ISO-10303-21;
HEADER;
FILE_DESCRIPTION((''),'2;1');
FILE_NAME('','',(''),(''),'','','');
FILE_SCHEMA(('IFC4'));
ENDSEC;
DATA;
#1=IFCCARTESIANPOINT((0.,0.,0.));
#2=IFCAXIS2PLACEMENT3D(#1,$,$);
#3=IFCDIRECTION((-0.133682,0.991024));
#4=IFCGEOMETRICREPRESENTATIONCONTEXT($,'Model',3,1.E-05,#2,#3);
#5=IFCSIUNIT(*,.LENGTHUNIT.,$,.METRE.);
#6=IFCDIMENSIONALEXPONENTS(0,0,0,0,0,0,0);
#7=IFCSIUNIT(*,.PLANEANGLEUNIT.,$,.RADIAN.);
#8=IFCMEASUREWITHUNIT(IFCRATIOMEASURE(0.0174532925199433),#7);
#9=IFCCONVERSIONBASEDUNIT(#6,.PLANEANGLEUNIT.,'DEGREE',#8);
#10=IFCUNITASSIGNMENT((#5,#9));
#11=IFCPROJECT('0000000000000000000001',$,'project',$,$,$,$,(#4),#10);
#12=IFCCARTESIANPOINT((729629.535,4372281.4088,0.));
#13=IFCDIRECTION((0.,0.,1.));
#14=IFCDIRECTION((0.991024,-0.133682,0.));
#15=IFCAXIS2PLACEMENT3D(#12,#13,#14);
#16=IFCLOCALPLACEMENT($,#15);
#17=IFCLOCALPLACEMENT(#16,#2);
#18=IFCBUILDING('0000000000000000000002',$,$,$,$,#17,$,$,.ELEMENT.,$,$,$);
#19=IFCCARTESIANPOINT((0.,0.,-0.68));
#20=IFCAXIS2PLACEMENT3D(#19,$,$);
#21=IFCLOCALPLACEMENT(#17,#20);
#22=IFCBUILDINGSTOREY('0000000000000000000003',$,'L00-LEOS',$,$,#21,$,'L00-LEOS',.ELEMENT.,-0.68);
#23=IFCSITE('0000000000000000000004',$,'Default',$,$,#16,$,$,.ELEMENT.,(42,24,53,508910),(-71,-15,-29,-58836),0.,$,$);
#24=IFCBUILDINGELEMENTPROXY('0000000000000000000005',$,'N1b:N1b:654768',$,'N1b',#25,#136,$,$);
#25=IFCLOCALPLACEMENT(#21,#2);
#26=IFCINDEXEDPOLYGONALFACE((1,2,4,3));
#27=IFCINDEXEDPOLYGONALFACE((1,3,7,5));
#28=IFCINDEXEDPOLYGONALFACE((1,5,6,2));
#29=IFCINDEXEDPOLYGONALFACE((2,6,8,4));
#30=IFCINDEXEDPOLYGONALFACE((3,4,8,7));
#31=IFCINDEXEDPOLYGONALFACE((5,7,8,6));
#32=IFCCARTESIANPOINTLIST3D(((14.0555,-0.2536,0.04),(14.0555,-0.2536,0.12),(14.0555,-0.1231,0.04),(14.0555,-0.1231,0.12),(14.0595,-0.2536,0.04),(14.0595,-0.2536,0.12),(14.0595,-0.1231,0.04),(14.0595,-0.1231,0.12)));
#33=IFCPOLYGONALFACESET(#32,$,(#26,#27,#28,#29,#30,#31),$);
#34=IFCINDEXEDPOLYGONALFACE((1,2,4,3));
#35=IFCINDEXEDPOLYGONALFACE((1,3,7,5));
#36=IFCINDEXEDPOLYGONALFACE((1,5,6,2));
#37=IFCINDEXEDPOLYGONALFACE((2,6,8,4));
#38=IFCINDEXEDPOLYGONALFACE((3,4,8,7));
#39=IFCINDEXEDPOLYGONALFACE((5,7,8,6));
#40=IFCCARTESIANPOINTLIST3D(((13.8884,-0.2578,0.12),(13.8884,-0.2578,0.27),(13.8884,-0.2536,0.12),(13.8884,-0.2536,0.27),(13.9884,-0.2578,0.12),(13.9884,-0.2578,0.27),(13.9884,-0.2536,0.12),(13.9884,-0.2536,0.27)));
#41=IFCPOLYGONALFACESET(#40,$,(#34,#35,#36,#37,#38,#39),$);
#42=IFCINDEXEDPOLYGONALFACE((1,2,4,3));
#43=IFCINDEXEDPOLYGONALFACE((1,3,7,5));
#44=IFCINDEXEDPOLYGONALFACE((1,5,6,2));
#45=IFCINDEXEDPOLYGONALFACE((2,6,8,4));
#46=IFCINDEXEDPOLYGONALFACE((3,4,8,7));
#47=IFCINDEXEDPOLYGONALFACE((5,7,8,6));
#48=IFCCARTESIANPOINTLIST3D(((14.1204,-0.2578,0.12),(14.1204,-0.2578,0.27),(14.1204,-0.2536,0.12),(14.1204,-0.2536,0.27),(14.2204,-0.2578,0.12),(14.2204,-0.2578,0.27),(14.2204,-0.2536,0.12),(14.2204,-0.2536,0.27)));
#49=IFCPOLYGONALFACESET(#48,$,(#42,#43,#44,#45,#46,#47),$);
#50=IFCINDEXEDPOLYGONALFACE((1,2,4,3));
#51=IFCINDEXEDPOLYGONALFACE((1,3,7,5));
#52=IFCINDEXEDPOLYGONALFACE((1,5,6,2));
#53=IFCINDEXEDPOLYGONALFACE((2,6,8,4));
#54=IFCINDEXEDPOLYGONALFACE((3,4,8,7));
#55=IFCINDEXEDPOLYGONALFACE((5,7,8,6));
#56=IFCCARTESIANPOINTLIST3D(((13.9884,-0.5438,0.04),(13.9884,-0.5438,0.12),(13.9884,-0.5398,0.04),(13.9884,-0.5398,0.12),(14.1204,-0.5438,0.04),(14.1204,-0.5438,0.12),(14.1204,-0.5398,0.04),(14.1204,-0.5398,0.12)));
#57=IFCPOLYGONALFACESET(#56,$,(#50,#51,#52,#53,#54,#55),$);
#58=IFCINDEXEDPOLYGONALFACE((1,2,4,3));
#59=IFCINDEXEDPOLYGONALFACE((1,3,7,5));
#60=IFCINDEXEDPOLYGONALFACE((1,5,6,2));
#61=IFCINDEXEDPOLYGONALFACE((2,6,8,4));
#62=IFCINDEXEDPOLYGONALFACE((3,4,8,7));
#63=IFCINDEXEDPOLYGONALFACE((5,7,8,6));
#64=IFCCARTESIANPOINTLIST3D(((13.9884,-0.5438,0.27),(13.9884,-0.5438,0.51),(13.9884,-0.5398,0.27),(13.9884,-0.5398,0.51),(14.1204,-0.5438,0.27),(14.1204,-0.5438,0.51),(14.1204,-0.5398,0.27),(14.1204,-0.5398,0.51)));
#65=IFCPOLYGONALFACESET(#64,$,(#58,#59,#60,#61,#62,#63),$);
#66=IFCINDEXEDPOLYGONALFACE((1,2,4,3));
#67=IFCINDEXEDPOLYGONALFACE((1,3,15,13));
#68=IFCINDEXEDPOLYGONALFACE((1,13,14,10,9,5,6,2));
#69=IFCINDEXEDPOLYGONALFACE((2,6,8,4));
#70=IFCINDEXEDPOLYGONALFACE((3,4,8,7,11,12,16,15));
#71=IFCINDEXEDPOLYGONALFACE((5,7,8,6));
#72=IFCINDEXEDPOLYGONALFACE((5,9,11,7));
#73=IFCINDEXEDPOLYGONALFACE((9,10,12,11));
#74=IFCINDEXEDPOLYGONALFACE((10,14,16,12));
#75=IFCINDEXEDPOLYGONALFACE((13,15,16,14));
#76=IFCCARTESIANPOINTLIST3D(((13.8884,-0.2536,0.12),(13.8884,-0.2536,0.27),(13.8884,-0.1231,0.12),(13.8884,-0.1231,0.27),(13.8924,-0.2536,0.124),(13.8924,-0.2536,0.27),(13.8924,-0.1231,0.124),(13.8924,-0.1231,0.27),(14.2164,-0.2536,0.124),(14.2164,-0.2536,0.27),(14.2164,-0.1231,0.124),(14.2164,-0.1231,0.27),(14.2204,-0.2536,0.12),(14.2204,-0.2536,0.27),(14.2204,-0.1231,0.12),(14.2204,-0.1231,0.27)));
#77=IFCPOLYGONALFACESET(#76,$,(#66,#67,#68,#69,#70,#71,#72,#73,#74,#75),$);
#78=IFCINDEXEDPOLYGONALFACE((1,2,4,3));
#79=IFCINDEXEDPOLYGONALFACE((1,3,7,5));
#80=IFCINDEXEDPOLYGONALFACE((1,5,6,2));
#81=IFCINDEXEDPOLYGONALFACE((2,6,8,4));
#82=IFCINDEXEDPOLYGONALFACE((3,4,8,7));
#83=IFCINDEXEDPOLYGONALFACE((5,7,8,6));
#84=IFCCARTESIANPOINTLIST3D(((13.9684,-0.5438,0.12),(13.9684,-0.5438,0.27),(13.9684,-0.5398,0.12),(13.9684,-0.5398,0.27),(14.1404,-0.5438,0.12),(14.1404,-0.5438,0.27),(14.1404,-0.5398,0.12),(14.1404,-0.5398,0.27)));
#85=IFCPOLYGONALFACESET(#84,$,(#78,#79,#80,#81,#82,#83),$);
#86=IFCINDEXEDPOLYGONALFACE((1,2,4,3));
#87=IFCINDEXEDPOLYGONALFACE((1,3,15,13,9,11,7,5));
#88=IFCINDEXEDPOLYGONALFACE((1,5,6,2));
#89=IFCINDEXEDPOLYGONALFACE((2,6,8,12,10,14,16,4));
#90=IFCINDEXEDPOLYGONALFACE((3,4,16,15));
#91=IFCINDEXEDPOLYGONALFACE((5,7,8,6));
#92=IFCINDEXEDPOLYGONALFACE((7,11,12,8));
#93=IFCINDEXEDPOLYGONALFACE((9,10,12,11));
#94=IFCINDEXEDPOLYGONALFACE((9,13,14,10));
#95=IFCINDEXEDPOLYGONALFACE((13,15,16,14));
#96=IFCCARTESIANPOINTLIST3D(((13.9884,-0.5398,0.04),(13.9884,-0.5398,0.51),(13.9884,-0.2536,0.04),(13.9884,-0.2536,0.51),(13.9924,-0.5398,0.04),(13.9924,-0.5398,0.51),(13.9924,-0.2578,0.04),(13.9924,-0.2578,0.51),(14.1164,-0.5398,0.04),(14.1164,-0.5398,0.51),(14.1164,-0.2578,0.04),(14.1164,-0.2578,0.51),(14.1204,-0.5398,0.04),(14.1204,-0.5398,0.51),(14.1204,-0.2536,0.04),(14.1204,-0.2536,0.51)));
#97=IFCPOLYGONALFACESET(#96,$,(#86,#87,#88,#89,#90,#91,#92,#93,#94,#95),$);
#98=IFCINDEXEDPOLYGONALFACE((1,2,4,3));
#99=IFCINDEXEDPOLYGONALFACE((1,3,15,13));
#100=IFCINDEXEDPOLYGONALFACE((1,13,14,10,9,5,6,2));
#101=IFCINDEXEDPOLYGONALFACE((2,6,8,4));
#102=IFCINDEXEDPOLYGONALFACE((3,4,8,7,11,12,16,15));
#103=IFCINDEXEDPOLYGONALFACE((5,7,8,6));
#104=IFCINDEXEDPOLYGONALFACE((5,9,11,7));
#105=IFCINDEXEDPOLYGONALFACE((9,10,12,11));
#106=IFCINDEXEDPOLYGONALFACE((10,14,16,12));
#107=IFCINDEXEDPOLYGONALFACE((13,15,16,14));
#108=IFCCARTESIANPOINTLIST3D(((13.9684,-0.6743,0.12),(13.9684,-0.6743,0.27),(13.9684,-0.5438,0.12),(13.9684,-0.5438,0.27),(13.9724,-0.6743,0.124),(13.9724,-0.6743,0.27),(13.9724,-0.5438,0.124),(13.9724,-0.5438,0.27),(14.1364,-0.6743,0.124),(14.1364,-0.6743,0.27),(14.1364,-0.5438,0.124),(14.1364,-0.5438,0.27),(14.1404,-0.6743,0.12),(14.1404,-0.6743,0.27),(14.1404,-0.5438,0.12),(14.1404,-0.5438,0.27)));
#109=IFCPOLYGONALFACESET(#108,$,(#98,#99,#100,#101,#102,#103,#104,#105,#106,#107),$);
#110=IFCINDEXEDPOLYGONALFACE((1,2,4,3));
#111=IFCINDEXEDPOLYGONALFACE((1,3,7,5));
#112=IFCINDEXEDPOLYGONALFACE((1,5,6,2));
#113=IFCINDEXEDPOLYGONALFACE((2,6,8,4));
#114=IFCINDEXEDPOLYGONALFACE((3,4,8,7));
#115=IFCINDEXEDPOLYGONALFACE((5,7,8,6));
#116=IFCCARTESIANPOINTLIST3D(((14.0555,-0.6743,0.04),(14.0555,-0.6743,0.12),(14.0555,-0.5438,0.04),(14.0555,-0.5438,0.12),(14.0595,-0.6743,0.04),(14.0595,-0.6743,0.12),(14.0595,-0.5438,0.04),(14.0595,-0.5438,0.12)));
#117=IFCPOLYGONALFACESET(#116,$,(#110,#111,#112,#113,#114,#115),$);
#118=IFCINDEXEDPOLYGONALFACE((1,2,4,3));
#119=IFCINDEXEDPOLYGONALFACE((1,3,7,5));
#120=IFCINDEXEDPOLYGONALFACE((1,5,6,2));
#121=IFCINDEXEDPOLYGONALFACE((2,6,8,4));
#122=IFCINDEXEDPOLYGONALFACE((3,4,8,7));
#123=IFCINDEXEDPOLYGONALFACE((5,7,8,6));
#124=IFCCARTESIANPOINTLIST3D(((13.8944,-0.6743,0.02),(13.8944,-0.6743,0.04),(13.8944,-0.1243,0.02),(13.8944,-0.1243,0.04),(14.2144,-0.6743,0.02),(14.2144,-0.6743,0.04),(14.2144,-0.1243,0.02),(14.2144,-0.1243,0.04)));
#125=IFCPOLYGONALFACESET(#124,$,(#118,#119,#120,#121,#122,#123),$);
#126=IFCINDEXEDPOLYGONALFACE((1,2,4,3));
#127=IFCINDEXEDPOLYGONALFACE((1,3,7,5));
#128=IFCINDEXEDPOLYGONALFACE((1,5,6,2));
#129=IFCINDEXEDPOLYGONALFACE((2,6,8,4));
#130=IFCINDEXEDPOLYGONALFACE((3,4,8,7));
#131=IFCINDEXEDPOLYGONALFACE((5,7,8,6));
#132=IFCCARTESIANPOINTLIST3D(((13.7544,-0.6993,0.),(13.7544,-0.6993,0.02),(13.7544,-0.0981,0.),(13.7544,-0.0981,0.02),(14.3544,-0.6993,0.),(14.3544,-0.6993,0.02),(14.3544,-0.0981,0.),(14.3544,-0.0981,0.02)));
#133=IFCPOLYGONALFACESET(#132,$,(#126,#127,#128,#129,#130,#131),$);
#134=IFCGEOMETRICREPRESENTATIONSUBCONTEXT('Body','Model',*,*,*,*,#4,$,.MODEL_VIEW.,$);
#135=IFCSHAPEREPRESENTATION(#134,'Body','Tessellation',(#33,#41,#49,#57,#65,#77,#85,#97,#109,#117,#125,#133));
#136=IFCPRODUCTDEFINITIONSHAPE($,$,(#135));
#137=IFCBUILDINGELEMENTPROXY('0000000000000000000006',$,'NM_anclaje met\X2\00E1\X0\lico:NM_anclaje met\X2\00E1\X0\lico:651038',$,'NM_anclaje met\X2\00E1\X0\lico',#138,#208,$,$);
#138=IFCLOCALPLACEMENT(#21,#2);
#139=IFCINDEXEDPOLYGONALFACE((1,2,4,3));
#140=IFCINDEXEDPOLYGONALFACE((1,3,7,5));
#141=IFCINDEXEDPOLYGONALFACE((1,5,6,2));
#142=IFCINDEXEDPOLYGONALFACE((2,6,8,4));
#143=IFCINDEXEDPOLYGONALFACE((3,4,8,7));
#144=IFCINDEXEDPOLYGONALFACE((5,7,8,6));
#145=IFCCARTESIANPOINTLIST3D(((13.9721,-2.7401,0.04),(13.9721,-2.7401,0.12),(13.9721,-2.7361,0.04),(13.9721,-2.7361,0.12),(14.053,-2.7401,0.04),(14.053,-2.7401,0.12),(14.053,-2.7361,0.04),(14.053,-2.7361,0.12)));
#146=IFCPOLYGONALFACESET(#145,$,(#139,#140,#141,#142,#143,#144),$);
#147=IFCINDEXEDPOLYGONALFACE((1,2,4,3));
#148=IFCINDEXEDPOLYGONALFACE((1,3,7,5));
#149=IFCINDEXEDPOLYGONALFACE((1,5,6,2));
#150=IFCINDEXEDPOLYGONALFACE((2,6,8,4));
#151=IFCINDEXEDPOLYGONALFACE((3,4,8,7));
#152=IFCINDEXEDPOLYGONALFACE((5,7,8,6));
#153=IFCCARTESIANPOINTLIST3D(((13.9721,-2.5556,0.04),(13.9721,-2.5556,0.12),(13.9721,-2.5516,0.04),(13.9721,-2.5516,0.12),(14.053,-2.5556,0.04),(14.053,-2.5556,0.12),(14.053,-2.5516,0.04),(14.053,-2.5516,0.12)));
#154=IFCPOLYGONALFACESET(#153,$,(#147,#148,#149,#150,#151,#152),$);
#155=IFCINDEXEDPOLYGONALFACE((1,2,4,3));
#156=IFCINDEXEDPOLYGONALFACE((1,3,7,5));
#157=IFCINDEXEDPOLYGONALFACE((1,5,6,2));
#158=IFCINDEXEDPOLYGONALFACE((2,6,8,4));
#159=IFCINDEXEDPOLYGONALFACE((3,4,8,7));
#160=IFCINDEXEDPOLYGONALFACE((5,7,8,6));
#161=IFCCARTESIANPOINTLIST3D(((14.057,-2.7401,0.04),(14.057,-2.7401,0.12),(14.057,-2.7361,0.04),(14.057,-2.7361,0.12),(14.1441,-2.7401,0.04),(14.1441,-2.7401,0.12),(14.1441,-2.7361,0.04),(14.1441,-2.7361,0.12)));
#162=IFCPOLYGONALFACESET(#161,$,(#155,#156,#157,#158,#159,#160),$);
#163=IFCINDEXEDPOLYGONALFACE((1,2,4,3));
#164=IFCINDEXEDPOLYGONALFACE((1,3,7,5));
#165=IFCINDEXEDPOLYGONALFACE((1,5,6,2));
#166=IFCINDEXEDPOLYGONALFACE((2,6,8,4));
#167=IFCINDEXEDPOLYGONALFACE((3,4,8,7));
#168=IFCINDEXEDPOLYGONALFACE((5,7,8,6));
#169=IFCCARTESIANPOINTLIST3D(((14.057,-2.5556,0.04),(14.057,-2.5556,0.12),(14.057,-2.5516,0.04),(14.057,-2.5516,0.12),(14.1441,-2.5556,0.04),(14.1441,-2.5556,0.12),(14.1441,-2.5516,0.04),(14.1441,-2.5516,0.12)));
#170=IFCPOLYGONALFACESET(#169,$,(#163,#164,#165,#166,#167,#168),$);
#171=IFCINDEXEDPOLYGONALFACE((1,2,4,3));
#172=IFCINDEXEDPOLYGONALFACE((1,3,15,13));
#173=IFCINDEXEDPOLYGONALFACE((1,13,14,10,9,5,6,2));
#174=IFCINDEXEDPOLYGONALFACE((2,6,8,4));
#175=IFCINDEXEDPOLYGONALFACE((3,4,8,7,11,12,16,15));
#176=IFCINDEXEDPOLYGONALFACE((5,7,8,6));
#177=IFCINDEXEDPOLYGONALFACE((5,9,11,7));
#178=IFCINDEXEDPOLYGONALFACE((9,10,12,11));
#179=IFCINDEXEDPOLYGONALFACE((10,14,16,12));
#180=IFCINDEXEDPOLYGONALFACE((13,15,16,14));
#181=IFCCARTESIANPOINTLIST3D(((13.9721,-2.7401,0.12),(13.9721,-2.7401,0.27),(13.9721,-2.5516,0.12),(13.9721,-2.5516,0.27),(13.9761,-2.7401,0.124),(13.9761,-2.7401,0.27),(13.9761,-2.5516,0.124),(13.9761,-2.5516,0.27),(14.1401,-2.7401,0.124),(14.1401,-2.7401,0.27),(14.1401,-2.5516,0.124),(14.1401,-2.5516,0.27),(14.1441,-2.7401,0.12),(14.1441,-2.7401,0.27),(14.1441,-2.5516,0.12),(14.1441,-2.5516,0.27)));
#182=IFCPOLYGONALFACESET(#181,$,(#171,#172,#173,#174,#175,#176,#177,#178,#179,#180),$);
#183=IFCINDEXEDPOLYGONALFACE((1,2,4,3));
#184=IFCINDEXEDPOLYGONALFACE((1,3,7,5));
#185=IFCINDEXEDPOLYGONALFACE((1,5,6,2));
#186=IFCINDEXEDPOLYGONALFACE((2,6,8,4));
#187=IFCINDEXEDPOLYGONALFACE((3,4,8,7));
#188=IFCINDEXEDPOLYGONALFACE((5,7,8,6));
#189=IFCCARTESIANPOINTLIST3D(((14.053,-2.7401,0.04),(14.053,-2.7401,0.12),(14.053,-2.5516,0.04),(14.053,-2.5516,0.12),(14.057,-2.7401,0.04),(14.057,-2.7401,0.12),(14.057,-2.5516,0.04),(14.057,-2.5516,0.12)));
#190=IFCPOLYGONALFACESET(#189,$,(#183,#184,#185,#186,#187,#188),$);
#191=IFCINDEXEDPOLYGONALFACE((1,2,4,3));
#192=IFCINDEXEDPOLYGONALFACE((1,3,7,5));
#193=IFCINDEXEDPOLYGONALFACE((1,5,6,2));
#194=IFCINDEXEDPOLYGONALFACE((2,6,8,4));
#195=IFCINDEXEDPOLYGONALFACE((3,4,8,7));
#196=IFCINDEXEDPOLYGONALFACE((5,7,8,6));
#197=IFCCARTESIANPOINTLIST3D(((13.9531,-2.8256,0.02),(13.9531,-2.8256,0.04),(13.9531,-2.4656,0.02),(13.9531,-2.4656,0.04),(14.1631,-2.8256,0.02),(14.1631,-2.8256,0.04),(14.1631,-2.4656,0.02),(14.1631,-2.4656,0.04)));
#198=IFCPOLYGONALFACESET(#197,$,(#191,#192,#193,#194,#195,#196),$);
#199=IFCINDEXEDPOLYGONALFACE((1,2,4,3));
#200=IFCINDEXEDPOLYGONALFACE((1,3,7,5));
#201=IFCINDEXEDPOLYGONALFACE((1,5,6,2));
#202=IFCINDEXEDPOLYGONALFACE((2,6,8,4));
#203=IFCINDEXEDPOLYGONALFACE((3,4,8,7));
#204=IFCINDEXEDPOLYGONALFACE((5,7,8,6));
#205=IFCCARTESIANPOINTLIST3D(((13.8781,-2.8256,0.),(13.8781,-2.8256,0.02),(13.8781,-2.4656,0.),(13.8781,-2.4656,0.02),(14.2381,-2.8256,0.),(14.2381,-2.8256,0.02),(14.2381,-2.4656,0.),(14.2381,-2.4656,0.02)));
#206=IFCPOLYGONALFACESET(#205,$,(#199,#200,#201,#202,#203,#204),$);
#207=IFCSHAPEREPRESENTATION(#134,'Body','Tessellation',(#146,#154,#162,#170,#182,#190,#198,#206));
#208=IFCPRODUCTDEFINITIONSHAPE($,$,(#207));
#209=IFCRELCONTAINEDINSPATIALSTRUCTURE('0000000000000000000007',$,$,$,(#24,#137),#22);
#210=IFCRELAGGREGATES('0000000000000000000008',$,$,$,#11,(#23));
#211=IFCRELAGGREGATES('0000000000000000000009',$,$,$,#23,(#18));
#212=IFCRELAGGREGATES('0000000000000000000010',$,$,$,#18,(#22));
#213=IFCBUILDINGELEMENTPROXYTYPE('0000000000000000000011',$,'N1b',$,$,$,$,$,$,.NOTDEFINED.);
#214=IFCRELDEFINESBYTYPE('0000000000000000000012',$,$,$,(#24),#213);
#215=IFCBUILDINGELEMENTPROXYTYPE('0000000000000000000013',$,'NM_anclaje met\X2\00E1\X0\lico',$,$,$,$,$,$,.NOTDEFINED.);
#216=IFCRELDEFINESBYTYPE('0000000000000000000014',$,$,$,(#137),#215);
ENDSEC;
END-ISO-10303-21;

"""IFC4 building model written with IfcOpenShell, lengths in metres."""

from ifc_helpers import new_model, entity, si_unit, converted_unit, direction, frame, frame_2d, origin, origin_2d_with_axis, place, context, subcontext, project, spatial, polyline, rectangle, outline, extrude, source, transform, mapped, type_object, type_shapes, element, save


model = new_model("IFC4")

# Units and contexts
model_context = context("Model", 3, precision=1e-05, world=origin(), true_north=direction((-0.133682, 0.991024)))
body_context = subcontext(model_context, "Body", "Model", "MODEL_VIEW")
ifc_project = project(units=[si_unit("LENGTHUNIT", "METRE"), converted_unit("PLANEANGLEUNIT", "DEGREE", entity("IfcRatioMeasure", 0.0174532925199433), si_unit("PLANEANGLEUNIT", "RADIAN"), dimensions=[0, 0, 0, 0, 0, 0, 0])], contexts=[model_context])

# Site, building, storey
site_placement = place(None, frame((729629.535, 4372281.4088, 0.0), z_axis=(0.0, 0.0, 1.0), x_axis=(0.991024, -0.133682, 0.0)))
site = spatial("IfcSite", under=ifc_project, at=site_placement, Name="Default", CompositionType="ELEMENT", RefLatitude=(42, 24, 53, 508910), RefLongitude=(-71, -15, -29, -58836), RefElevation=0.0)
building_placement = place(site_placement, origin())
building = spatial("IfcBuilding", under=site, at=building_placement, CompositionType="ELEMENT")
storey_placement = place(building_placement, frame((0.0, 0.0, -0.68)))
storey = spatial("IfcBuildingStorey", under=building, at=storey_placement, Name="L00-LEOS", LongName="L00-LEOS", CompositionType="ELEMENT", Elevation=-0.68)

# Building element proxies
building_element_proxy_type_1 = type_object("IfcBuildingElementProxyType", Name="N1b")
shared_shape_1 = source(origin(), body_context, "Body", "SweptSolid", [
    extrude(rectangle(XDim=0.004, YDim=0.1305, at=origin_2d_with_axis()), frame((0.2103, 0.0, 0.04), z_axis=(0.0, 0.0, 1.0), x_axis=(0.0, -1.0, 0.0)), (0.0, 0.0, 1.0), 0.08),
    extrude(rectangle(XDim=0.1, YDim=0.0042, at=frame_2d((0.0, 0.0), x_axis=(1.0, 0.0))), frame((0.143, 0.1191, 0.12), z_axis=(0.0, 0.0, 1.0), x_axis=(0.0, 1.0, 0.0)), (0.0, 0.0, 1.0), 0.15),
    extrude(rectangle(XDim=0.1, YDim=0.0042, at=origin_2d_with_axis()), frame((0.143, -0.1129, 0.12), z_axis=(0.0, 0.0, 1.0), x_axis=(0.0, 1.0, 0.0)), (0.0, 0.0, 1.0), 0.15),
    extrude(rectangle(XDim=0.132, YDim=0.004, at=frame_2d((0.0, 0.0), x_axis=(1.0, 0.0))), frame((-0.1431, 0.0031, 0.04), z_axis=(0.0, 0.0, 1.0), x_axis=(0.0, 1.0, 0.0)), (0.0, 0.0, 1.0), 0.08),
    extrude(rectangle(XDim=0.132, YDim=0.004, at=frame_2d((0.0, 0.0), x_axis=(1.0, 0.0))), frame((-0.1431, 0.0031, 0.27), z_axis=(0.0, 0.0, 1.0), x_axis=(0.0, 1.0, 0.0)), (0.0, 0.0, 1.0), 0.24),
    extrude(outline(polyline([(-0.076, -0.166), (0.074, -0.166), (0.074, -0.162), (-0.072, -0.162), (-0.072, 0.162), (0.074, 0.162), (0.074, 0.166), (-0.076, 0.166), (-0.076, -0.166)])), frame((0.1451, 0.0031, 0.196), z_axis=(1.0, 0.0, 0.0), x_axis=(0.0, 0.0, 1.0)), (0.0, 0.0, 1.0), 0.1305),
    extrude(rectangle(XDim=0.172, YDim=0.004, at=frame_2d((0.0, 0.0), x_axis=(1.0, 0.0))), frame((-0.1431, 0.0031, 0.12), z_axis=(0.0, 0.0, 1.0), x_axis=(0.0, 1.0, 0.0)), (0.0, 0.0, 1.0), 0.15),
    extrude(outline(polyline([(-0.1441, -0.066), (0.142, -0.066), (0.142, -0.062), (-0.14, -0.062), (-0.14, 0.062), (0.142, 0.062), (0.142, 0.066), (-0.1441, 0.066), (-0.1441, -0.066)])), frame((0.001, 0.0031, 0.04), z_axis=(0.0, 0.0, 1.0), x_axis=(-1.0, 0.0, 0.0)), (0.0, 0.0, 1.0), 0.47),
    extrude(outline(polyline([(-0.076, -0.086), (0.074, -0.086), (0.074, -0.082), (-0.072, -0.082), (-0.072, 0.082), (0.074, 0.082), (0.074, 0.086), (-0.076, 0.086), (-0.076, -0.086)])), frame((-0.2756, 0.0031, 0.196), z_axis=(1.0, 0.0, 0.0), x_axis=(0.0, 0.0, 1.0)), (0.0, 0.0, 1.0), 0.1305),
    extrude(rectangle(XDim=0.004, YDim=0.1305, at=origin_2d_with_axis()), frame((-0.2103, 0.0, 0.04), z_axis=(0.0, 0.0, 1.0), x_axis=(0.0, -1.0, 0.0)), (0.0, 0.0, 1.0), 0.08),
    extrude(rectangle(XDim=0.55, YDim=0.32, at=frame_2d((0.0, 0.0), x_axis=(1.0, 0.0))), frame((-0.0006, 0.0031, 0.02), z_axis=(0.0, 0.0, 1.0), x_axis=(-1.0, 0.0, 0.0)), (0.0, 0.0, 1.0), 0.02),
    extrude(rectangle(XDim=0.6012, YDim=0.6, at=frame_2d((0.0, 0.0), x_axis=(1.0, 0.0))), frame((0.0, 0.0031, 0.0), z_axis=(0.0, 0.0, 1.0), x_axis=(-1.0, 0.0, 0.0)), (0.0, 0.0, 1.0), 0.02),
])
type_shapes(building_element_proxy_type_1, [shared_shape_1])
proxy_1_placement = place(storey_placement, frame((14.0575, -0.3987, 0.0), z_axis=(0.0, 0.0, 1.0), x_axis=(0.0, 1.0, 0.0)))
element("IfcBuildingElementProxy", 1, at=proxy_1_placement, inside=storey, type_object=building_element_proxy_type_1, Name="N1b:N1b:654768", ObjectType="N1b", context=body_context, shape_type="MappedRepresentation", body=[
    mapped(shared_shape_1, transform((0.0, 0.0, 0.0), scale=1.0)),
])
building_element_proxy_type_2 = type_object("IfcBuildingElementProxyType", Name="NM_anclaje metálico")
shared_shape_2 = source(origin(), body_context, "Body", "SweptSolid", [
    extrude(rectangle(XDim=0.0809, YDim=0.004, at=frame_2d((0.0, 0.0), x_axis=(1.0, 0.0))), frame((0.0925, -0.0424, 0.04), z_axis=(0.0, 0.0, 1.0), x_axis=(0.0, 1.0, 0.0)), (0.0, 0.0, 1.0), 0.08),
    extrude(rectangle(XDim=0.0809, YDim=0.004, at=frame_2d((0.0, 0.0), x_axis=(1.0, 0.0))), frame((-0.092, -0.0424, 0.04), z_axis=(0.0, 0.0, 1.0), x_axis=(0.0, 1.0, 0.0)), (0.0, 0.0, 1.0), 0.08),
    extrude(rectangle(XDim=0.0871, YDim=0.004, at=origin_2d_with_axis()), frame((0.0925, 0.0456, 0.04), z_axis=(0.0, 0.0, 1.0), x_axis=(0.0, 1.0, 0.0)), (0.0, 0.0, 1.0), 0.08),
    extrude(rectangle(XDim=0.0871, YDim=0.004, at=frame_2d((0.0, 0.0), x_axis=(1.0, 0.0))), frame((-0.092, 0.0456, 0.04), z_axis=(0.0, 0.0, 1.0), x_axis=(0.0, 1.0, 0.0)), (0.0, 0.0, 1.0), 0.08),
    extrude(outline(polyline([(-0.076, -0.086), (0.074, -0.086), (0.074, -0.082), (-0.072, -0.082), (-0.072, 0.082), (0.074, 0.082), (0.074, 0.086), (-0.076, 0.086), (-0.076, -0.086)])), frame((-0.094, 0.0031, 0.196), z_axis=(1.0, 0.0, 0.0), x_axis=(0.0, 0.0, 1.0)), (0.0, 0.0, 1.0), 0.1885),
    extrude(rectangle(XDim=0.004, YDim=0.1885, at=frame_2d((0.0, 0.0), x_axis=(1.0, 0.0))), frame((0.0002, 0.0, 0.04), z_axis=(0.0, 0.0, 1.0), x_axis=(0.0, -1.0, 0.0)), (0.0, 0.0, 1.0), 0.08),
    extrude(rectangle(XDim=0.36, YDim=0.21, at=frame_2d((0.0, 0.0), x_axis=(1.0, 0.0))), frame((0.0, 0.0031, 0.02), z_axis=(0.0, 0.0, 1.0), x_axis=(-1.0, 0.0, 0.0)), (0.0, 0.0, 1.0), 0.02),
    extrude(rectangle(XDim=0.36, YDim=0.36, at=frame_2d((0.0, 0.0), x_axis=(1.0, 0.0))), frame((0.0, 0.0031, 0.0), z_axis=(0.0, 0.0, 1.0), x_axis=(-1.0, 0.0, 0.0)), (0.0, 0.0, 1.0), 0.02),
])
type_shapes(building_element_proxy_type_2, [shared_shape_2])
for number, where, z_axis, x_axis, name in (
    (2, (14.055, -2.6456, 0.0), (0.0, 0.0, 1.0), (0.0, -1.0, 0.0), "NM_anclaje metálico:NM_anclaje metálico:651038"),
):
    element("IfcBuildingElementProxy", number, at=place(storey_placement, frame(where, z_axis=z_axis, x_axis=x_axis)), inside=storey, type_object=building_element_proxy_type_2, Name=name, ObjectType="NM_anclaje metálico", context=body_context, shape_type="MappedRepresentation", body=[
        mapped(shared_shape_2, transform((0.0, 0.0, 0.0), scale=1.0)),
    ])

save(model, "model.ifc")
